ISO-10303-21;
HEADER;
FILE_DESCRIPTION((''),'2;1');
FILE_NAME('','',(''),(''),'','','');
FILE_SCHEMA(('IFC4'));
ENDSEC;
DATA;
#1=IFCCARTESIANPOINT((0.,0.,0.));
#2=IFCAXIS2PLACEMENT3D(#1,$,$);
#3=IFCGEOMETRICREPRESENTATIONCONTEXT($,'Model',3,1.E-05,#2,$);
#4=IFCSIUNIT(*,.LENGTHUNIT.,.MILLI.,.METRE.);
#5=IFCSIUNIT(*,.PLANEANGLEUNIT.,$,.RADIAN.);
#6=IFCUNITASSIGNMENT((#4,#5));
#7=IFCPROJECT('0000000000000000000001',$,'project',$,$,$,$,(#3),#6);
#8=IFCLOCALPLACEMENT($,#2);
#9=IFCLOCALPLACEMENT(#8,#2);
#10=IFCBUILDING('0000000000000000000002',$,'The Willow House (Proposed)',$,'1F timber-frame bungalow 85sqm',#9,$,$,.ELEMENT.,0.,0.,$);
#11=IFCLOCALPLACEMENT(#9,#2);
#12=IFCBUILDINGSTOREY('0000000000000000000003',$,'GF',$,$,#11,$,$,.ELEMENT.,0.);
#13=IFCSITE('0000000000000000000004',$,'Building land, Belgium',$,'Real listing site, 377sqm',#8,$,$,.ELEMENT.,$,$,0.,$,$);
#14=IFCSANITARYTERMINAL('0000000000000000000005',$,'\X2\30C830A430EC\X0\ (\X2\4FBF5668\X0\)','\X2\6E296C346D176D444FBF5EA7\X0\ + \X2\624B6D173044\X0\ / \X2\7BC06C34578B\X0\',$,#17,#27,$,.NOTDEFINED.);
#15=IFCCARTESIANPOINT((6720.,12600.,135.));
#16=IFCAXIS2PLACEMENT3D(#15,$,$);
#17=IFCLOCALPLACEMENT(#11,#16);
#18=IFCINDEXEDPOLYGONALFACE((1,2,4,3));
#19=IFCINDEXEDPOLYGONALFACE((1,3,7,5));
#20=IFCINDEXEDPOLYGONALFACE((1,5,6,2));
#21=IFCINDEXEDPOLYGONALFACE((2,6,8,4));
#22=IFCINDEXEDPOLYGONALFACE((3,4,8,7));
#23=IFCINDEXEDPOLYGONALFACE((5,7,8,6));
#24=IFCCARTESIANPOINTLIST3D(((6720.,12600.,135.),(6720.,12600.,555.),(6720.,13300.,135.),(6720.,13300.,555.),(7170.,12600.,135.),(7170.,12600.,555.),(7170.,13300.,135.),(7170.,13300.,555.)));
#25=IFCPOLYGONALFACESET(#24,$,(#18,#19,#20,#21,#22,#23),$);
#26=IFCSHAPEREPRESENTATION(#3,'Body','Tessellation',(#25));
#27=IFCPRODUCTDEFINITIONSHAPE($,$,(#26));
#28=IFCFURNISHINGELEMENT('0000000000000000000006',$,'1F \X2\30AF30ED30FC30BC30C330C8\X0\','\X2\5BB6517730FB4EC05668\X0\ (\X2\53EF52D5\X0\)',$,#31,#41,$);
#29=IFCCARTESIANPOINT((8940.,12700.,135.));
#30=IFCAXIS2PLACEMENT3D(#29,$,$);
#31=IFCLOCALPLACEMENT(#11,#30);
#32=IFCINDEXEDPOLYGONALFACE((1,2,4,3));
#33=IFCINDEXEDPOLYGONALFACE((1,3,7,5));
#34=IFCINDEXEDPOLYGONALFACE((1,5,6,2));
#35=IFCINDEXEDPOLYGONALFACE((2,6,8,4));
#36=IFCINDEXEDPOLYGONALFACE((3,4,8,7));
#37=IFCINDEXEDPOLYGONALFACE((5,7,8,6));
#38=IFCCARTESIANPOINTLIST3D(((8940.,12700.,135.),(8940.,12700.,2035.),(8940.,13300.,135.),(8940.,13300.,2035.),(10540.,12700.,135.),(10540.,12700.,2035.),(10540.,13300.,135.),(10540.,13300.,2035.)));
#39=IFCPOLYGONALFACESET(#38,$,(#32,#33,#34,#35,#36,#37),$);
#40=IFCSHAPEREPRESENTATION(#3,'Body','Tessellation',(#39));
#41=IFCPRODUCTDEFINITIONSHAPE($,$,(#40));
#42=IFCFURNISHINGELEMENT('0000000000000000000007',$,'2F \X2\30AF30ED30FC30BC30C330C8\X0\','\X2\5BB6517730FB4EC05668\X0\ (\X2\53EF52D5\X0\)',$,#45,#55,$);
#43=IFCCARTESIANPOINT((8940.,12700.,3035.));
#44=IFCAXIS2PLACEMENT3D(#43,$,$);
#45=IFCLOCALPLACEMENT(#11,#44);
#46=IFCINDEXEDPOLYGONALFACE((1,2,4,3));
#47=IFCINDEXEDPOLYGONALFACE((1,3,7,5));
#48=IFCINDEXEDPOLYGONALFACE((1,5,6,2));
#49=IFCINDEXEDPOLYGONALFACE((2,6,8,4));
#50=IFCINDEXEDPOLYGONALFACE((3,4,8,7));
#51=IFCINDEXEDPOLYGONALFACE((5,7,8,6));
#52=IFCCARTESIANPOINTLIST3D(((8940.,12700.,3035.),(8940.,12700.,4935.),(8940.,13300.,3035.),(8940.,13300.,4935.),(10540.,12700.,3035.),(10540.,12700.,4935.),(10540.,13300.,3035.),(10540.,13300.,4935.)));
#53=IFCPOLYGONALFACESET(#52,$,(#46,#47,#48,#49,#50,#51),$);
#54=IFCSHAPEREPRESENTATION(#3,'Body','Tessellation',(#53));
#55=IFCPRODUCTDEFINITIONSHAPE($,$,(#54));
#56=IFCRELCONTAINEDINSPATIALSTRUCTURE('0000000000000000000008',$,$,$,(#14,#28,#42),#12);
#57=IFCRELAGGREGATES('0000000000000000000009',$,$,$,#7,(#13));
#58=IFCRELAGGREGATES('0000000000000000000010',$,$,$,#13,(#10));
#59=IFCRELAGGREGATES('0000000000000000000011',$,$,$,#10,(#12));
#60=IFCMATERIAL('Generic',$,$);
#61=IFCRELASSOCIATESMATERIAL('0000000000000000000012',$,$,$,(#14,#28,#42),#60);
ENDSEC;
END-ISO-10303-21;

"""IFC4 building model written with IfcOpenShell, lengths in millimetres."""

from ifc_helpers import new_model, si_unit, frame, frame_2d, origin, place, context, project, spatial, rectangle, extrude, material, element, save


model = new_model("IFC4")

# Units and contexts
model_context = context("Model", 3, precision=1e-05, world=origin())
ifc_project = project(units=[si_unit("LENGTHUNIT", "METRE", prefix="MILLI"), si_unit("PLANEANGLEUNIT", "RADIAN")], contexts=[model_context])

# Site, building, storey
site_placement = place(None, origin())
site = spatial("IfcSite", under=ifc_project, at=site_placement, Name="Building land, Belgium", ObjectType="Real listing site, 377sqm", CompositionType="ELEMENT", RefElevation=0.0)
building_placement = place(site_placement, origin())
building = spatial("IfcBuilding", under=site, at=building_placement, Name="The Willow House (Proposed)", ObjectType="1F timber-frame bungalow 85sqm", CompositionType="ELEMENT", ElevationOfRefHeight=0.0, ElevationOfTerrain=0.0)
storey_placement = place(building_placement, origin())
storey = spatial("IfcBuildingStorey", under=building, at=storey_placement, Name="GF", CompositionType="ELEMENT", Elevation=0.0)

# Sanitary terminal
ifc_material_1 = material(Name="Generic")
sanitary_terminal_1_placement = place(storey_placement, frame((6720.0, 12600.0, 135.0)))
element("IfcSanitaryTerminal", 1, at=sanitary_terminal_1_placement, inside=storey, material=ifc_material_1, Name="トイレ (便器)", Description="温水洗浄便座 + 手洗い / 節水型", PredefinedType="NOTDEFINED", context=model_context, shape_type="SweptSolid", body=[
    extrude(rectangle(XDim=450.0, YDim=700.0, at=frame_2d((225.0, 350.0))), frame((6720.0, 12600.0, 135.0)), (0.0, 0.0, 1.0), 420.0),
])

# Furnishing elements
furnishing_1_placement = place(storey_placement, frame((8940.0, 12700.0, 135.0)))
element("IfcFurnishingElement", 2, at=furnishing_1_placement, inside=storey, material=ifc_material_1, Name="1F クローゼット", Description="家具・什器 (可動)", context=model_context, shape_type="SweptSolid", body=[
    extrude(rectangle(XDim=1600.0, YDim=600.0, at=frame_2d((800.0, 300.0))), frame((8940.0, 12700.0, 135.0)), (0.0, 0.0, 1.0), 1900.0),
])
furnishing_2_placement = place(storey_placement, frame((8940.0, 12700.0, 3035.0)))
element("IfcFurnishingElement", 3, at=furnishing_2_placement, inside=storey, material=ifc_material_1, Name="2F クローゼット", Description="家具・什器 (可動)", context=model_context, shape_type="SweptSolid", body=[
    extrude(rectangle(XDim=1600.0, YDim=600.0, at=frame_2d((800.0, 300.0))), frame((8940.0, 12700.0, 3035.0)), (0.0, 0.0, 1.0), 1900.0),
])

save(model, "model.ifc")
